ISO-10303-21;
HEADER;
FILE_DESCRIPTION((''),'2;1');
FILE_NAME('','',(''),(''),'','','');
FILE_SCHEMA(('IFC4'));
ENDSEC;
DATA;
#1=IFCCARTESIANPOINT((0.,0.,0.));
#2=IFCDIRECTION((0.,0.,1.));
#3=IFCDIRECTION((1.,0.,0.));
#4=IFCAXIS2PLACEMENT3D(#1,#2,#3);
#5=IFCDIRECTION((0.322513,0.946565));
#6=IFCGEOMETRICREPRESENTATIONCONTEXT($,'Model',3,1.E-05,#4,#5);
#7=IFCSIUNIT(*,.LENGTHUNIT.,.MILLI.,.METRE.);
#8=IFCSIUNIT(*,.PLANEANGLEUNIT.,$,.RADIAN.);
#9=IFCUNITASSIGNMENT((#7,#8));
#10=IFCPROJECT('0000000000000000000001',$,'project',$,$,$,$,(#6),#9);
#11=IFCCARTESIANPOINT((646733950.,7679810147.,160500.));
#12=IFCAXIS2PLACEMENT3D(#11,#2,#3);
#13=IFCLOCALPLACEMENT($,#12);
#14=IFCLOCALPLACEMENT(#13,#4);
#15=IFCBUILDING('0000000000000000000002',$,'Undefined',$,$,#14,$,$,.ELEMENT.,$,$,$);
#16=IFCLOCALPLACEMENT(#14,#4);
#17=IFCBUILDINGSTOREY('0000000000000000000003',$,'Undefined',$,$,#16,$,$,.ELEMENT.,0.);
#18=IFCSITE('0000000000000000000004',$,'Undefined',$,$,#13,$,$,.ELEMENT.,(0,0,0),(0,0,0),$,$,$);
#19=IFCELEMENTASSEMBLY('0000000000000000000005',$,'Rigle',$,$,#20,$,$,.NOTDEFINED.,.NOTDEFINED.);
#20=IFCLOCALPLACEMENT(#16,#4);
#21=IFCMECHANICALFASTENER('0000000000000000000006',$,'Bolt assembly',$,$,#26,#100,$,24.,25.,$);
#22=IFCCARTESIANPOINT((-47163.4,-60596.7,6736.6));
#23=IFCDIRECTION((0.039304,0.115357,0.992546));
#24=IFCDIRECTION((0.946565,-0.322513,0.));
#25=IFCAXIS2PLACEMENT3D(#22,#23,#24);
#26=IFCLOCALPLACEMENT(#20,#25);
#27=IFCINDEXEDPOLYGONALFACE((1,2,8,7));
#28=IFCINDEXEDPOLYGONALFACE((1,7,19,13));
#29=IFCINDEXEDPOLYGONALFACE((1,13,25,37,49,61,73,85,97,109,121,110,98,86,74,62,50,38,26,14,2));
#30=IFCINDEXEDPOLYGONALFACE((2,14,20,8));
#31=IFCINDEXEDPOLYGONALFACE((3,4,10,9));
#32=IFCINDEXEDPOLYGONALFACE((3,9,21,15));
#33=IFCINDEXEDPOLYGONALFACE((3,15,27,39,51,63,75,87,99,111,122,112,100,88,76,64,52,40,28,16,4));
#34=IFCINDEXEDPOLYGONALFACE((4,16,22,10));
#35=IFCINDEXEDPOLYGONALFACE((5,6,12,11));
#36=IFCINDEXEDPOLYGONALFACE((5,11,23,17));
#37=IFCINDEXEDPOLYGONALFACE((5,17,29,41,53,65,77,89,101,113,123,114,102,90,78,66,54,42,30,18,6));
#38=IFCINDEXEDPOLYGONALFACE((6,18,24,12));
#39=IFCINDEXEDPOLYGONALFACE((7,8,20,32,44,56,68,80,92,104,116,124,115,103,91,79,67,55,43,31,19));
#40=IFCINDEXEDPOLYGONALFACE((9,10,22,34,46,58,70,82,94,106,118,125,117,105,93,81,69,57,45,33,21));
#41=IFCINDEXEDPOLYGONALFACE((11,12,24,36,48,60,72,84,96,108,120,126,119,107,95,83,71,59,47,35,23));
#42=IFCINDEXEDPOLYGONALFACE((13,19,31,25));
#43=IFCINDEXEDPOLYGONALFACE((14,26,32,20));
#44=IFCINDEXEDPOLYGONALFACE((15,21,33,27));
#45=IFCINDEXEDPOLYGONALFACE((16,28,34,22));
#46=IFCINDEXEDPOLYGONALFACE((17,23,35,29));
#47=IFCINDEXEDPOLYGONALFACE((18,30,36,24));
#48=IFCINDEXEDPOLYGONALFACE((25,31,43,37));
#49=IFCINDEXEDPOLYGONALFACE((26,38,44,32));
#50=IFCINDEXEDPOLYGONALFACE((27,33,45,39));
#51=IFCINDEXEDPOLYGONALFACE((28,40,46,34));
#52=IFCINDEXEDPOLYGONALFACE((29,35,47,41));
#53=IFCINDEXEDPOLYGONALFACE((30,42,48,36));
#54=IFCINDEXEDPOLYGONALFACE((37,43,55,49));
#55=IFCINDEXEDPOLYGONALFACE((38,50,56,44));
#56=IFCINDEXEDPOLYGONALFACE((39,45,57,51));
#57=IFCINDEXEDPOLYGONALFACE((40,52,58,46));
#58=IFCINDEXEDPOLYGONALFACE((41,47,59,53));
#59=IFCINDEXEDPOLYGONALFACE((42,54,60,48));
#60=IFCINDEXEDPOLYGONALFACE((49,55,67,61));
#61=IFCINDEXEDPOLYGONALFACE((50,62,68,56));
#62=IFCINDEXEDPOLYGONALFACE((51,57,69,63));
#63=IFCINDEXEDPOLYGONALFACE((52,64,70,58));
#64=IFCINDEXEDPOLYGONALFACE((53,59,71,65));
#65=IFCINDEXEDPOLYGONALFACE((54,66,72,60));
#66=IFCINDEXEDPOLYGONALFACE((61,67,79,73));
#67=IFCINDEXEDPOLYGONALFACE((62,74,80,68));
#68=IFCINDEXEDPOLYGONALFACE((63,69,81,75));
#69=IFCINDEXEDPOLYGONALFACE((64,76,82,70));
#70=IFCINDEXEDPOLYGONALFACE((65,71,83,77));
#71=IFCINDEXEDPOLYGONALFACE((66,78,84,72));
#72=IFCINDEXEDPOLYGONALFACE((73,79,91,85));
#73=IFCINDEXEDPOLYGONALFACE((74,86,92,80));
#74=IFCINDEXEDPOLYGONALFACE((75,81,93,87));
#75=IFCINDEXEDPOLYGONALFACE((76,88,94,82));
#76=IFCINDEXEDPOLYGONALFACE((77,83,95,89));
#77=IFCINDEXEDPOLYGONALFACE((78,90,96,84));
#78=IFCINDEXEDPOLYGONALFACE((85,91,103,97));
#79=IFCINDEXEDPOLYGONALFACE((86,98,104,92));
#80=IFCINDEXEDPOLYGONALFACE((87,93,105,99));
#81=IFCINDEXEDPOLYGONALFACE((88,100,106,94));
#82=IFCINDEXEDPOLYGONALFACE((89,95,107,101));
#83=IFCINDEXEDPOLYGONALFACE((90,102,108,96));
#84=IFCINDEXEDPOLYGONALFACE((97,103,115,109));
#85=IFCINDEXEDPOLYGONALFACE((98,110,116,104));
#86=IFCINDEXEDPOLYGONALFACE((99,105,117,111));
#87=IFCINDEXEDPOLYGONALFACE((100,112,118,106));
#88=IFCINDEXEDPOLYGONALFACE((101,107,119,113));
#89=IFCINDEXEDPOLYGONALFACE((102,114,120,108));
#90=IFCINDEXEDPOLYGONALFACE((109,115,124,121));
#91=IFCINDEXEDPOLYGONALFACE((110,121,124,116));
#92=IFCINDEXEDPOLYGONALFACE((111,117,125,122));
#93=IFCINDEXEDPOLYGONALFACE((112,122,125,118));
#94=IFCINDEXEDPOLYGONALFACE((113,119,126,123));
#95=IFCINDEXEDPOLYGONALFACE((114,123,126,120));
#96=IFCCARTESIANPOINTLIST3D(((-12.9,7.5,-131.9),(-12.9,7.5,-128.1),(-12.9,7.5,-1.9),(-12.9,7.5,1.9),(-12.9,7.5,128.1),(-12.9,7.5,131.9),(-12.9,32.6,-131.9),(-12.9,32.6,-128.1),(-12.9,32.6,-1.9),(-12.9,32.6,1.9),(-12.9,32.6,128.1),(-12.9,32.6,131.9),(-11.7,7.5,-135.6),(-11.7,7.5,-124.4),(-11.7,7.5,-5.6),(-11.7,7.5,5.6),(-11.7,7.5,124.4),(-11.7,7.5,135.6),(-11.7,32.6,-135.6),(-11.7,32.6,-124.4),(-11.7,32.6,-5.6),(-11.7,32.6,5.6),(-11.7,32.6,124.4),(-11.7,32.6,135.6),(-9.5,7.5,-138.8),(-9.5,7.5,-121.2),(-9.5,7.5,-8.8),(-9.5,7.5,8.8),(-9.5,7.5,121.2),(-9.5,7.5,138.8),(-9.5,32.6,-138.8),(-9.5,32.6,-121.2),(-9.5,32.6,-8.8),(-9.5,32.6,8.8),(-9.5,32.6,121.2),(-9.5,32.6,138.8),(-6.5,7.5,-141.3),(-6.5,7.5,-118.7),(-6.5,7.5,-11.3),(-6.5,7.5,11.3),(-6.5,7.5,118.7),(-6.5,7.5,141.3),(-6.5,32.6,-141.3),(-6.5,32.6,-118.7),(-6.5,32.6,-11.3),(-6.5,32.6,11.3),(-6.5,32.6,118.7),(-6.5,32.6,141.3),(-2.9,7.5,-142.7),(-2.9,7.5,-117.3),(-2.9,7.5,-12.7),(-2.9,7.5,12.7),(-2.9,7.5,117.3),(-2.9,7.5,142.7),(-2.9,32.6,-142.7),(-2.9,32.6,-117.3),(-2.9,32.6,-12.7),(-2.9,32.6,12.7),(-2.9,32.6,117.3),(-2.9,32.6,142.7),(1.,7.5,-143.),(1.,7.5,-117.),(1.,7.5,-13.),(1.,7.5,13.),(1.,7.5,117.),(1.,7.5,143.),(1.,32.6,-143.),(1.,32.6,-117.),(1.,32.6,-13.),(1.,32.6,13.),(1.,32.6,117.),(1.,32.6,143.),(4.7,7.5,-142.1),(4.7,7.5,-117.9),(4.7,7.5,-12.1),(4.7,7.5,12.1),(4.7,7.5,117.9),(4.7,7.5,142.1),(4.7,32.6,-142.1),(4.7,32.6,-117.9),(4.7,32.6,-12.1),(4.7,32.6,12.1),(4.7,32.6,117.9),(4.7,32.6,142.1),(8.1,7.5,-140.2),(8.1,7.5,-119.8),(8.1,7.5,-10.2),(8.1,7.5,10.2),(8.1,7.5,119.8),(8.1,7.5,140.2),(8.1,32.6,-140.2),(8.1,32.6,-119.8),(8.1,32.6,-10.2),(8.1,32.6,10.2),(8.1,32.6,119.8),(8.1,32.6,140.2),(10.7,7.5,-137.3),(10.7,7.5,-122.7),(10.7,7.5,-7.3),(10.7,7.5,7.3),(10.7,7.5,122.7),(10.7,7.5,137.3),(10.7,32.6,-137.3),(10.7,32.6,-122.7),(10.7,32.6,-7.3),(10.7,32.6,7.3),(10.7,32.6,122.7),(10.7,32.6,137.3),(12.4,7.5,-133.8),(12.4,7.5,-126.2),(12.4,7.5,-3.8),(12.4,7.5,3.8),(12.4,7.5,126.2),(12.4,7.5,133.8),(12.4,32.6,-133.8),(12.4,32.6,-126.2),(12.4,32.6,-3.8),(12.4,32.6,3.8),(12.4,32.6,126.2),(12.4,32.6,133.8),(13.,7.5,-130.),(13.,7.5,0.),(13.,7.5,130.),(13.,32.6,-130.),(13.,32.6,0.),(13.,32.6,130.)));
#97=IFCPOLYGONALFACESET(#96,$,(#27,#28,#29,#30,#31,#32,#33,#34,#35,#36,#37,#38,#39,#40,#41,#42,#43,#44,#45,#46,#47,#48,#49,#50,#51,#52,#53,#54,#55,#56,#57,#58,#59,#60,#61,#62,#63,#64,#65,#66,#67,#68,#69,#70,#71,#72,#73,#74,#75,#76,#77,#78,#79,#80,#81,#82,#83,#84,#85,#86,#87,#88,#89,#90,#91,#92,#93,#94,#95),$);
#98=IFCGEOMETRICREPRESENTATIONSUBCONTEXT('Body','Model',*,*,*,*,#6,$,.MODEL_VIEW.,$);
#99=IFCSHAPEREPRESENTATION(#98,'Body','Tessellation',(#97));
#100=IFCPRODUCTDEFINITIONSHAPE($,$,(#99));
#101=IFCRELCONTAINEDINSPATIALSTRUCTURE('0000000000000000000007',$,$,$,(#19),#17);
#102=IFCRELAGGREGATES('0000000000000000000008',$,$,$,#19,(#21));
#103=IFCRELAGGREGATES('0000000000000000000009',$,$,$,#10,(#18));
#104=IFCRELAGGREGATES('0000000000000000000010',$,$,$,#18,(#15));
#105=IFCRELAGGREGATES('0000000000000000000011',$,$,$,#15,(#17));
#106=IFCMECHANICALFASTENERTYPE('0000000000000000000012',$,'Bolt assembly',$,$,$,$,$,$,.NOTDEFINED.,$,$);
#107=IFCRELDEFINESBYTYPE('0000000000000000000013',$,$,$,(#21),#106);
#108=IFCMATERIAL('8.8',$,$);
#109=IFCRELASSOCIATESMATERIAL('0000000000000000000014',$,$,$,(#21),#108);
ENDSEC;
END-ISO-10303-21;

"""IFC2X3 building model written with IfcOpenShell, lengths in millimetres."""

from ifc_helpers import new_model, si_unit, direction, frame, origin_with_axes, origin_2d_with_axis, place, context, subcontext, project, spatial, circle, extrude, source, transform, mapped, material, type_object, element, aggregate, save


model = new_model("IFC2X3")

# Units and contexts
model_context = context("Model", 3, precision=1e-05, world=origin_with_axes(), true_north=direction((0.322513, 0.946565)))
body_context = subcontext(model_context, "Body", "Model", "MODEL_VIEW")
ifc_project = project(units=[si_unit("LENGTHUNIT", "METRE", prefix="MILLI"), si_unit("PLANEANGLEUNIT", "RADIAN")], contexts=[model_context])

# Site, building, storey
site_placement = place(None, frame((646733950.0, 7679810147.0, 160500.0), z_axis=(0.0, 0.0, 1.0), x_axis=(1.0, 0.0, 0.0)))
site = spatial("IfcSite", under=ifc_project, at=site_placement, Name="Undefined", CompositionType="ELEMENT", RefLatitude=(0, 0, 0), RefLongitude=(0, 0, 0))
building_placement = place(site_placement, origin_with_axes())
building = spatial("IfcBuilding", under=site, at=building_placement, Name="Undefined", CompositionType="ELEMENT")
storey_placement = place(building_placement, origin_with_axes())
storey = spatial("IfcBuildingStorey", under=building, at=storey_placement, Name="Undefined", CompositionType="ELEMENT", Elevation=0.0)

# Element assembly
assembly_1_placement = place(storey_placement, origin_with_axes())
assembly_1 = element("IfcElementAssembly", 1, at=assembly_1_placement, inside=storey, Name="Rigle", AssemblyPlace="NOTDEFINED", PredefinedType="NOTDEFINED")

# Shared definitions
ifc_material_1 = material(Name="8.8")
mechanical_fastener_type = type_object("IfcMechanicalFastenerType", Name="Bolt assembly")

# Mechanical fastener
shared_shape_1 = source(origin_with_axes(), body_context, "Body", "SweptSolid", [
    extrude(circle(Radius=13.0, at=origin_2d_with_axis()), frame((0.0, 7.5, 0.0), z_axis=(0.0, 1.0, 0.0), x_axis=(1.0, 0.0, 0.0)), (0.0, 0.0, 1.0), 25.1),
])
mechanical_fastener_1_placement = place(assembly_1_placement, frame((-47163.4, -60596.7, 6736.6), z_axis=(0.039304, 0.115357, 0.992546), x_axis=(0.946565, -0.322513, 0.0)))
mechanical_fastener_1 = element("IfcMechanicalFastener", 2, at=mechanical_fastener_1_placement, type_object=mechanical_fastener_type, material=ifc_material_1, Name="Bolt assembly", NominalDiameter=24.0, NominalLength=25.0, context=body_context, shape_type="MappedRepresentation", body=[
    mapped(shared_shape_1, transform((0.0, 0.0, -130.0))),
    mapped(shared_shape_1, transform((0.0, 0.0, 0.0))),
    mapped(shared_shape_1, transform((0.0, 0.0, 130.0))),
])
aggregate(assembly_1, [mechanical_fastener_1])

save(model, "model.ifc")
